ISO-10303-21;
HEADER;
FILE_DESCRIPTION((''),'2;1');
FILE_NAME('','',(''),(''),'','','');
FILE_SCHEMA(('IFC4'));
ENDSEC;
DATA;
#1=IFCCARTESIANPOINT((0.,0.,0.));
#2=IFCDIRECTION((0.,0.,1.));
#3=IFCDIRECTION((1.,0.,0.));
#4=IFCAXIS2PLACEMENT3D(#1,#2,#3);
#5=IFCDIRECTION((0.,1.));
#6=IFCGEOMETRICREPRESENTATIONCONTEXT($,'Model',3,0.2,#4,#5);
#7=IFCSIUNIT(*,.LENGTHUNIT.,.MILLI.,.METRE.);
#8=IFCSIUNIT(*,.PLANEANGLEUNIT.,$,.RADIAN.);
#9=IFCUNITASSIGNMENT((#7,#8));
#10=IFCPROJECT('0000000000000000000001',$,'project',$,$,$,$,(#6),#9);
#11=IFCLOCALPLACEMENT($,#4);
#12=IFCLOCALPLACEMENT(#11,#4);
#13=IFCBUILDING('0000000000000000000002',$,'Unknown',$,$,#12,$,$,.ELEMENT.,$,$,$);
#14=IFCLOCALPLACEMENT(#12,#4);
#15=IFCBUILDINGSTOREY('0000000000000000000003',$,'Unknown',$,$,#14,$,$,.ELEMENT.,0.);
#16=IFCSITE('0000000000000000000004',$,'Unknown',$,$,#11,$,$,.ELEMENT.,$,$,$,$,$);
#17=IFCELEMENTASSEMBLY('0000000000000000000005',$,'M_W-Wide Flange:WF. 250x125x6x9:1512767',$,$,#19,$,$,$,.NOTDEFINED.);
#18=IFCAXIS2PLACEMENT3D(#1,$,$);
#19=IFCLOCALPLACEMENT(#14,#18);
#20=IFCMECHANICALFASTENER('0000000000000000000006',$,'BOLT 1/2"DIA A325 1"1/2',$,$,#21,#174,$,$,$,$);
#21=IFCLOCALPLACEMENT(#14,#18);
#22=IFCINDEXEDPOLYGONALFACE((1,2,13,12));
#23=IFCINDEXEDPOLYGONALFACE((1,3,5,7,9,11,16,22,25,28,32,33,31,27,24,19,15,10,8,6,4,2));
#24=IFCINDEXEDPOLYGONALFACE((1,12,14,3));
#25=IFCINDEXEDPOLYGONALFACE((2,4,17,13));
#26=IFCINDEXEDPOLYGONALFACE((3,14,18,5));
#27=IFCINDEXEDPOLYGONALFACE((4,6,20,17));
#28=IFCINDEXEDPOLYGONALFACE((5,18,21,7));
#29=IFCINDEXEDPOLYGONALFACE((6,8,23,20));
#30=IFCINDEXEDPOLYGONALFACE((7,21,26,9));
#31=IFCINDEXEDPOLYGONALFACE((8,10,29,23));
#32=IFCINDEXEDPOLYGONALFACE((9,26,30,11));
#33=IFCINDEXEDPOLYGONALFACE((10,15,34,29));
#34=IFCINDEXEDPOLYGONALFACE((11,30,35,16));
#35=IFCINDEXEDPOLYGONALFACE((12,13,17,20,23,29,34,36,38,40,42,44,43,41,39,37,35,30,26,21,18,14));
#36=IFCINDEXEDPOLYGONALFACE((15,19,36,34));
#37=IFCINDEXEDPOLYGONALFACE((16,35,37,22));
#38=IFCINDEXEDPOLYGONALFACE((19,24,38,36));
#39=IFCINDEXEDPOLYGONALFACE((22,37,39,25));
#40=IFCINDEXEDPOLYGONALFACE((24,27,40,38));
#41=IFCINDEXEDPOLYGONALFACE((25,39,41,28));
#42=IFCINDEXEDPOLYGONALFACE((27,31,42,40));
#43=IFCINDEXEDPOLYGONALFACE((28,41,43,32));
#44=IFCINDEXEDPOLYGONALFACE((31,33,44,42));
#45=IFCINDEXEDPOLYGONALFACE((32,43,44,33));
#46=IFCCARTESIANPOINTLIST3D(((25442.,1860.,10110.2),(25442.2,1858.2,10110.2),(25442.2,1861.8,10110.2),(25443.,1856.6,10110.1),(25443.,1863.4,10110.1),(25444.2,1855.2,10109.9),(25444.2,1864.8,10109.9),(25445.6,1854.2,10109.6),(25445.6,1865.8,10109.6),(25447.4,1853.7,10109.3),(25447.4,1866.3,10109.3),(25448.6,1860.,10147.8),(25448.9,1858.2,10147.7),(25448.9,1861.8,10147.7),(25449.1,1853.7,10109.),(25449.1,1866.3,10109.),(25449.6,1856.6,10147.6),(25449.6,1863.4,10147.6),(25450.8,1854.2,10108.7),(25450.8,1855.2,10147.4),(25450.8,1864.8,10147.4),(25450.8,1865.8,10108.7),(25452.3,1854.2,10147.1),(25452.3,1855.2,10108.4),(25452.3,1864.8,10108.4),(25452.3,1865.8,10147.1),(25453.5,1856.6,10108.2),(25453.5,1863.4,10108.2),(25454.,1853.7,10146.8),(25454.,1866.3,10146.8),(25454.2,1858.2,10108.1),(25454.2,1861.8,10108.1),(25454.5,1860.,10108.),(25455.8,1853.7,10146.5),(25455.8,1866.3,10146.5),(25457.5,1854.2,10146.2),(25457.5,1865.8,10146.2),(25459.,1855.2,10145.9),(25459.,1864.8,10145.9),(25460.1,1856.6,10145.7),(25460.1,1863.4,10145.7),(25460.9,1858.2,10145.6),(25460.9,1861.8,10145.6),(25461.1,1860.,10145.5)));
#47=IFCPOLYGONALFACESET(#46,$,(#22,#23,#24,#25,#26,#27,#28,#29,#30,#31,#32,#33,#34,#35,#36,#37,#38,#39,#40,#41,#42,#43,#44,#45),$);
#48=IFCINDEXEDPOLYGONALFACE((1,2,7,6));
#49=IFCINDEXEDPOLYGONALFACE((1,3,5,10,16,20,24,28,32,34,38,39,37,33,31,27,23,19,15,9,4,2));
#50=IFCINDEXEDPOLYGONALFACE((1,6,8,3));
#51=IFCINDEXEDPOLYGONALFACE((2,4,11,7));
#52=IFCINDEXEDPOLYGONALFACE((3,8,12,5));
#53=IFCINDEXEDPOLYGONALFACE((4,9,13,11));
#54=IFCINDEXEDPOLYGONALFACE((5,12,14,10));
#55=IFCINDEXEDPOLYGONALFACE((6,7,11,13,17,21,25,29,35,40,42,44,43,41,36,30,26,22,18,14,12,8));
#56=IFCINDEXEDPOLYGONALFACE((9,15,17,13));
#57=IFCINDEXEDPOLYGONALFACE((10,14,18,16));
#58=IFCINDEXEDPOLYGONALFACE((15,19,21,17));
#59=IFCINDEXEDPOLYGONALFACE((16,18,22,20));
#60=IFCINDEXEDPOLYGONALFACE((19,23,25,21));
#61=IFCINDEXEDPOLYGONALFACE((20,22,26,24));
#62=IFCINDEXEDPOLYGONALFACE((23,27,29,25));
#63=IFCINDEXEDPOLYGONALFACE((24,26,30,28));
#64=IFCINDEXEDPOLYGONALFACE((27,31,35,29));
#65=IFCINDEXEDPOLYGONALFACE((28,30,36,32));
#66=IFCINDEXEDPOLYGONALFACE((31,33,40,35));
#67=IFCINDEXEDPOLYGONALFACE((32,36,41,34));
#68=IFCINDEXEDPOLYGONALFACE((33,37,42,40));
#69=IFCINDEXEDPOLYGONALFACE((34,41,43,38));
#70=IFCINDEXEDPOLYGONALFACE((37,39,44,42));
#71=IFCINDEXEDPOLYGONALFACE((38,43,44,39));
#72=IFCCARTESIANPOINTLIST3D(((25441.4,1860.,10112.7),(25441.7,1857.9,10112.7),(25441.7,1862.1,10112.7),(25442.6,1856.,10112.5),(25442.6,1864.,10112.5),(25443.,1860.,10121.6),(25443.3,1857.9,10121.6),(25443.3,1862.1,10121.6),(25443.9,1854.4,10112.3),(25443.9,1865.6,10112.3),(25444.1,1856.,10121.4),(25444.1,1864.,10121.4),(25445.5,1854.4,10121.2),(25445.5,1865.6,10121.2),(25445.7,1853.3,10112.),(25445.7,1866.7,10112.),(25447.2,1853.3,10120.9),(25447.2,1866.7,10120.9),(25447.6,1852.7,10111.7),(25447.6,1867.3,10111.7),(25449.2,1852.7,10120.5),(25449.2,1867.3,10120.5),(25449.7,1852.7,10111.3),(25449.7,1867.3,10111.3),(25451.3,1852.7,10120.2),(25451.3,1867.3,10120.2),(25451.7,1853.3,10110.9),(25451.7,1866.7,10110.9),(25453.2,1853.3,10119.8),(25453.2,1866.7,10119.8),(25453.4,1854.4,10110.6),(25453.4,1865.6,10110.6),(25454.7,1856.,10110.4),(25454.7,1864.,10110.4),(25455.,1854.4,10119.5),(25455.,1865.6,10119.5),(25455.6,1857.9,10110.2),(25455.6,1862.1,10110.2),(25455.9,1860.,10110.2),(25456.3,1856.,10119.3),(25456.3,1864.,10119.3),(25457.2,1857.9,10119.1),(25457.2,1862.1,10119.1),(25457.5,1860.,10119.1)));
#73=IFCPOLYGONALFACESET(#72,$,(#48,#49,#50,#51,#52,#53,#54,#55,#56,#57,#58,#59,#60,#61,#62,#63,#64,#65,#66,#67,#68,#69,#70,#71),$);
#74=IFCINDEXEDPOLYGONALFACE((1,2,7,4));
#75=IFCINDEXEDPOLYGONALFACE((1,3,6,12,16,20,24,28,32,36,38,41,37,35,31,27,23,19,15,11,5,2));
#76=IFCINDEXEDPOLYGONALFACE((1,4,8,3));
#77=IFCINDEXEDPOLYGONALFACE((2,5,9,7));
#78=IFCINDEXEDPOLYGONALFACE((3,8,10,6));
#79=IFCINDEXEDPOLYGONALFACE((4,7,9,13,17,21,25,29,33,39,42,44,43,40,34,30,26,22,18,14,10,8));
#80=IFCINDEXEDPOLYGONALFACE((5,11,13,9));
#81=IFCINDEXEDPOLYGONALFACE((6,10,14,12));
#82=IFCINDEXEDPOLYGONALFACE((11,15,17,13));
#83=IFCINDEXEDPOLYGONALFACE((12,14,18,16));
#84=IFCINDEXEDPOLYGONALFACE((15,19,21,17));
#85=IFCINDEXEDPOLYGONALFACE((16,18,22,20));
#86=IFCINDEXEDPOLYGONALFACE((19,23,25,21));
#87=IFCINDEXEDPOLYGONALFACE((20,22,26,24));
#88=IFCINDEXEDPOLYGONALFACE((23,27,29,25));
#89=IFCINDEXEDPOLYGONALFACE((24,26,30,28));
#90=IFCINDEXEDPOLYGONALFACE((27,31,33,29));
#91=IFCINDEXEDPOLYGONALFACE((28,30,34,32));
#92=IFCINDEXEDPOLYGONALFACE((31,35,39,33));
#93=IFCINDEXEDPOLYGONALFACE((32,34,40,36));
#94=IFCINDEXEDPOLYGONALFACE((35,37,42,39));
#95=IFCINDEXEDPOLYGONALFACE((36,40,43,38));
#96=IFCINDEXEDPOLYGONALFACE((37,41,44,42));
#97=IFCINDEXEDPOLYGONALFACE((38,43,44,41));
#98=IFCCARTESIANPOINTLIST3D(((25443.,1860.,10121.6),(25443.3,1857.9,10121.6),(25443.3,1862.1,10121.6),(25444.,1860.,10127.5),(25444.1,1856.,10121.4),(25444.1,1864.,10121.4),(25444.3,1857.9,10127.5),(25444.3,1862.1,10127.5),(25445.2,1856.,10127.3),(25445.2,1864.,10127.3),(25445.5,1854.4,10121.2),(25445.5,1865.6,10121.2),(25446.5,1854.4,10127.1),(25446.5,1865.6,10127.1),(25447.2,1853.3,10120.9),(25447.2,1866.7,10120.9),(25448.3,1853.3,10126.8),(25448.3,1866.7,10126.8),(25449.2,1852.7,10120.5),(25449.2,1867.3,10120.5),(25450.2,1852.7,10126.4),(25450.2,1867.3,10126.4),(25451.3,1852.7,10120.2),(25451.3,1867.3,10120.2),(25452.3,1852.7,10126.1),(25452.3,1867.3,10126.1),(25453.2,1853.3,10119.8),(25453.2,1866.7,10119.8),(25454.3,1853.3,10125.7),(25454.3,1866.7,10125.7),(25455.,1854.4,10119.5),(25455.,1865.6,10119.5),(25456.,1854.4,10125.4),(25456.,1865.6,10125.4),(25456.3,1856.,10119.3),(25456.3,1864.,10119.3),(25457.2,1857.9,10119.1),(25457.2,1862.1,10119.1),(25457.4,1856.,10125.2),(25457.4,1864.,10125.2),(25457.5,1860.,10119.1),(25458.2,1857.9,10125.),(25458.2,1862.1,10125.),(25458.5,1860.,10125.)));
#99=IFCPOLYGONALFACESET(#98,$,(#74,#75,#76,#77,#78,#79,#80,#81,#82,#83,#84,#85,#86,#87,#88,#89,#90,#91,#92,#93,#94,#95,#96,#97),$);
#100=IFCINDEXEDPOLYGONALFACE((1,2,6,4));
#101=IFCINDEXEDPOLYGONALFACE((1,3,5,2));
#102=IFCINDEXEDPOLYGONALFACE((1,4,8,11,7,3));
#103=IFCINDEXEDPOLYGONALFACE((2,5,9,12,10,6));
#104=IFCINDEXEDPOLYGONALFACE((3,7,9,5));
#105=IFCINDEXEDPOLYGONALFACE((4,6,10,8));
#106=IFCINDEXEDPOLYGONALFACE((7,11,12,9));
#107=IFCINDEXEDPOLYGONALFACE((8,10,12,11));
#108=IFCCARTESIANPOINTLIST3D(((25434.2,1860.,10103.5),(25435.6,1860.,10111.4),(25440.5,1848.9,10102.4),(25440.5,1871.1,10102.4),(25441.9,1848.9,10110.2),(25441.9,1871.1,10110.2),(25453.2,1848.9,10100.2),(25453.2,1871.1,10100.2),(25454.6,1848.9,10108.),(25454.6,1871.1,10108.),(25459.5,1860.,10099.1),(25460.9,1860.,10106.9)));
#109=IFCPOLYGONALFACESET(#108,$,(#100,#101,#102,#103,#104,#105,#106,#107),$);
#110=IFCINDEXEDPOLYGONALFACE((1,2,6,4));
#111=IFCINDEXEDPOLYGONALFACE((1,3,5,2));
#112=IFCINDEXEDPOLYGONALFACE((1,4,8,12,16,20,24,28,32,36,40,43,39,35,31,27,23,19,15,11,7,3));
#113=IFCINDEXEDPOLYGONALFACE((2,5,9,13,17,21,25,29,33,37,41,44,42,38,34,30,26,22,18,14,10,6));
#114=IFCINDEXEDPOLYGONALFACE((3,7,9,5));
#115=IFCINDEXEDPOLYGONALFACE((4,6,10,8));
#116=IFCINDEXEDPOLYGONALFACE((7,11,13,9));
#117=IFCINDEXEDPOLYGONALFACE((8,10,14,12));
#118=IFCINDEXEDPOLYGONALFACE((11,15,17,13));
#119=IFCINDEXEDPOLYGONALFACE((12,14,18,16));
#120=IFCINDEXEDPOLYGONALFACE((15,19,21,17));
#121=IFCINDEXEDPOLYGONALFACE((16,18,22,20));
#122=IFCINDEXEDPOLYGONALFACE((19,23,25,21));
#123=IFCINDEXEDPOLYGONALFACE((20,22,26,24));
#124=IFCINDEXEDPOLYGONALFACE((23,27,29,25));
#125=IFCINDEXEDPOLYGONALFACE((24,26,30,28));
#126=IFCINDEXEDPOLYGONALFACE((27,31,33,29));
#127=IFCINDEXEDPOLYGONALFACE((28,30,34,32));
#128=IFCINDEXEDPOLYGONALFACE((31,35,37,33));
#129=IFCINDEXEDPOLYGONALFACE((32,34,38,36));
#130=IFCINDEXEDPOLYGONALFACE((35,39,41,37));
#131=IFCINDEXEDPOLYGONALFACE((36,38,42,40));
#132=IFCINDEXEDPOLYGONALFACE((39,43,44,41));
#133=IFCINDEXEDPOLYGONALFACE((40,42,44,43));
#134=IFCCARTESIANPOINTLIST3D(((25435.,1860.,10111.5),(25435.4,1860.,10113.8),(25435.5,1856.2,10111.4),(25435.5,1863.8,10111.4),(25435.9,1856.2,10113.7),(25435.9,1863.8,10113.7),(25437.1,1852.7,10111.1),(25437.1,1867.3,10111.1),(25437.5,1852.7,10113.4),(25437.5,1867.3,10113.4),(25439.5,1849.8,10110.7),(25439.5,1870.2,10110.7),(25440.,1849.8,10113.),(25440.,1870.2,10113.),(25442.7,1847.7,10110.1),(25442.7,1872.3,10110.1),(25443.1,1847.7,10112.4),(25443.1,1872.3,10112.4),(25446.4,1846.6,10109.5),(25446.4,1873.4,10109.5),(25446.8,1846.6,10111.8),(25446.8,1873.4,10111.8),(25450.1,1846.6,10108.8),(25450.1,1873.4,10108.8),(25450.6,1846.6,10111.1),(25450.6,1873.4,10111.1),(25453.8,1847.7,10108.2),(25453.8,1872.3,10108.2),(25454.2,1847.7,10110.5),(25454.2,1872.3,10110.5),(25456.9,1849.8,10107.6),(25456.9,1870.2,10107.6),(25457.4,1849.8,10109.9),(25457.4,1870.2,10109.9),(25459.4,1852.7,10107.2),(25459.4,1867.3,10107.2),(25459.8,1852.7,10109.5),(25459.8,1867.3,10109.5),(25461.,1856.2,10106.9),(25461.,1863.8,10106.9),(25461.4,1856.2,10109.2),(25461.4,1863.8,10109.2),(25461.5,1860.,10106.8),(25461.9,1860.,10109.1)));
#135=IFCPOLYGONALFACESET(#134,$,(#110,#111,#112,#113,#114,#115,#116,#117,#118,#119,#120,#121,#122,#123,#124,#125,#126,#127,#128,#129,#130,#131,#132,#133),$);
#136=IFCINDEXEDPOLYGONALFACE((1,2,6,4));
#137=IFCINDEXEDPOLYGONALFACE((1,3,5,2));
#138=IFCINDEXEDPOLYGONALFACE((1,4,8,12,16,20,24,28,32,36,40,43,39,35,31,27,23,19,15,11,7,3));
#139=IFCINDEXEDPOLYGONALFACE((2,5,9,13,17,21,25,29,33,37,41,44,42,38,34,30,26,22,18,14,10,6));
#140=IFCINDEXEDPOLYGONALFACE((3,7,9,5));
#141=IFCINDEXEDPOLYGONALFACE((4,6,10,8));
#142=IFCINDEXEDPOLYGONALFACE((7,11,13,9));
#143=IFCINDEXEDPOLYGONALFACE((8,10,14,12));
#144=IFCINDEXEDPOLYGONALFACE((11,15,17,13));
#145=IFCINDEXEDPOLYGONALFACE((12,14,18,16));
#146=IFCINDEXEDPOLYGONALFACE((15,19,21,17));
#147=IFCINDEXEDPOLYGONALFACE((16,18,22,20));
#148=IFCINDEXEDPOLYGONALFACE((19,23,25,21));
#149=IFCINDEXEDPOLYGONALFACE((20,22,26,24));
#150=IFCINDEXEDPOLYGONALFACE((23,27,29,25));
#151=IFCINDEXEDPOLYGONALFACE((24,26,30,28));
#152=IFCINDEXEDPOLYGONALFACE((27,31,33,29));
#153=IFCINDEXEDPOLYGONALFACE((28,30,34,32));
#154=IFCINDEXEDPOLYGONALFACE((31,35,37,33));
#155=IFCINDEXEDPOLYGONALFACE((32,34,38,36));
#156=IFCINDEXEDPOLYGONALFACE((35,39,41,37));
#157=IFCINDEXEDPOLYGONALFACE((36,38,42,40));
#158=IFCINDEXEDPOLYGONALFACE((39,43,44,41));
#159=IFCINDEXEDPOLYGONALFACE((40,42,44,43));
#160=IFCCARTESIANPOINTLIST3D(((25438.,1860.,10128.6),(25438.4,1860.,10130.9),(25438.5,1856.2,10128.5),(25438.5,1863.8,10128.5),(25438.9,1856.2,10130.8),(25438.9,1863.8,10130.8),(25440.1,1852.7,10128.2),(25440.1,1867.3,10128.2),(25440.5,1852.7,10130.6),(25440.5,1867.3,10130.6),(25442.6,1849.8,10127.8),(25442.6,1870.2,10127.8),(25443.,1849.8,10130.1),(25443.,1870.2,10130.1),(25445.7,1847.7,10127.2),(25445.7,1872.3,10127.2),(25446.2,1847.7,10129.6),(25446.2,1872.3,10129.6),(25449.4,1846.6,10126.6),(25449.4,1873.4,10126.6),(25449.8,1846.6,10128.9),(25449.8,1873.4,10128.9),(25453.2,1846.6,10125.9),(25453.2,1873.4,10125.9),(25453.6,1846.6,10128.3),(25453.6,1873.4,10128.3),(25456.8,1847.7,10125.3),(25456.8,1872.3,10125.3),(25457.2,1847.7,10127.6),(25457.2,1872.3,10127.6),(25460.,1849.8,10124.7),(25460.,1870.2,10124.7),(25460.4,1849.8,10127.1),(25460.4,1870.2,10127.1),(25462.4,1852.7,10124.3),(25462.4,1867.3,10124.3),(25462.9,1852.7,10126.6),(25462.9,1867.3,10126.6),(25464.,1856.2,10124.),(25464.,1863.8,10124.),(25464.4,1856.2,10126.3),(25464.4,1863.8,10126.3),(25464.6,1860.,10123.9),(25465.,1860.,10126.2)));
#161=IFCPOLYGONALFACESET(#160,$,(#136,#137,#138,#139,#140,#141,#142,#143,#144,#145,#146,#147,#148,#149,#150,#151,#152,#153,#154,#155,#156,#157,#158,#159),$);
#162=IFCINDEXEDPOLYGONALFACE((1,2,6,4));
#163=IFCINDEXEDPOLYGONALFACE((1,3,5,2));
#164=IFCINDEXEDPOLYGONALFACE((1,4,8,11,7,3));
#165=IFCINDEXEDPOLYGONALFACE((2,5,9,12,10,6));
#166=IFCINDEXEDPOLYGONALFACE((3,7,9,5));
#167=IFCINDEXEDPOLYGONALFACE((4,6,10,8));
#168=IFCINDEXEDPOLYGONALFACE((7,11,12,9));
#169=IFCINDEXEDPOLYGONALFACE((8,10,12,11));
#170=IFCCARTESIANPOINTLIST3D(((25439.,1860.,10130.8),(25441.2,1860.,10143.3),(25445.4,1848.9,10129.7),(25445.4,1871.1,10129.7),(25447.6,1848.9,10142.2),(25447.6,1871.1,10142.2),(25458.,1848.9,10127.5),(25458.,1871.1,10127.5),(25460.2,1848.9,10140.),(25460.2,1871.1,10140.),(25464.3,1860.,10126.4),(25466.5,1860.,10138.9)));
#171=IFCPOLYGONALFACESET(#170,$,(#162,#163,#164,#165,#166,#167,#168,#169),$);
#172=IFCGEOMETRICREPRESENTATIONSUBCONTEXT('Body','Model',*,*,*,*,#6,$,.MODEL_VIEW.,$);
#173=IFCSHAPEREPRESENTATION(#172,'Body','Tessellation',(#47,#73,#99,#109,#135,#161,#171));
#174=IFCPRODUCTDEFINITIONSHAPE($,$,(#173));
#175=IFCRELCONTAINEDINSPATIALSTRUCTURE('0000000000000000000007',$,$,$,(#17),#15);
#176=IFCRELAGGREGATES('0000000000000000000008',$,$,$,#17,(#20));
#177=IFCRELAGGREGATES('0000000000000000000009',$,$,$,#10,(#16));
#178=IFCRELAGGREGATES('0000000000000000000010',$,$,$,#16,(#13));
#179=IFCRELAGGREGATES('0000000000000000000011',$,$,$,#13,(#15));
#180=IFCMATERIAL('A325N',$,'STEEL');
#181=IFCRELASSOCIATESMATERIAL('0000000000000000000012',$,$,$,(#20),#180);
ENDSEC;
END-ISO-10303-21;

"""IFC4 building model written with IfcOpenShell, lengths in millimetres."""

from ifc_helpers import new_model, si_unit, direction, frame, origin_with_axes, place, context, subcontext, project, spatial, line, arc, indexed_curve, outline, extrude, source, transform, mapped, material, element, aggregate, save


model = new_model("IFC4")

# Units and contexts
model_context = context("Model", 3, precision=0.2, world=origin_with_axes(), true_north=direction((0.0, 1.0)))
body_context = subcontext(model_context, "Body", "Model", "MODEL_VIEW")
ifc_project = project(units=[si_unit("LENGTHUNIT", "METRE", prefix="MILLI"), si_unit("PLANEANGLEUNIT", "RADIAN")], contexts=[model_context])

# Site, building, storey
site_placement = place(None, origin_with_axes())
site = spatial("IfcSite", under=ifc_project, at=site_placement, Name="Unknown", CompositionType="ELEMENT")
building_placement = place(site_placement, origin_with_axes())
building = spatial("IfcBuilding", under=site, at=building_placement, Name="Unknown", CompositionType="ELEMENT")
storey_placement = place(building_placement, origin_with_axes())
storey = spatial("IfcBuildingStorey", under=building, at=storey_placement, Name="Unknown", CompositionType="ELEMENT", Elevation=0.0)

# Shared definitions
ifc_material_1 = material(Name="A325N", Category="STEEL")
shared_shape_1 = source(origin_with_axes(), body_context, "Body", "SweptSolid", [
    extrude(outline(indexed_curve([(6.3, 0.0), (0.0, 6.3), (-6.3, 0.0), (0.0, -6.3)], segments=[arc(1, 2, 3), arc(3, 4, 1)])), frame((0.0, 0.0, 17.4), z_axis=(0.0, 0.0, -1.0), x_axis=(0.0, 1.0, 0.0)), (0.0, 0.0, 1.0), 38.1),
    extrude(outline(indexed_curve([(7.3, 0.0), (0.0, 7.3), (-7.3, 0.0), (0.0, -7.3)], segments=[arc(1, 2, 3), arc(3, 4, 1)])), frame((0.0, 0.0, 15.0), z_axis=(0.0, 0.0, -1.0), x_axis=(0.0, 1.0, 0.0)), (0.0, 0.0, 1.0), 9.0),
    extrude(outline(indexed_curve([(7.3, 0.0), (0.0, 7.3), (-7.3, 0.0), (0.0, -7.3)], segments=[arc(1, 2, 3), arc(3, 4, 1)])), frame((0.0, 0.0, 6.0), z_axis=(0.0, 0.0, -1.0), x_axis=(0.0, 1.0, 0.0)), (0.0, 0.0, 1.0), 6.0),
    extrude(outline(indexed_curve([(12.8, 0.0), (6.4, 11.1), (-6.4, 11.1), (-12.8, 0.0), (-6.4, -11.1), (6.4, -11.1)], segments=[line(1, 2, 3, 4, 5, 6, 1)])), frame((0.0, 0.0, 25.3), z_axis=(0.0, 0.0, -1.0), x_axis=(0.0, 1.0, 0.0)), (0.0, 0.0, 1.0), 7.9),
    extrude(outline(indexed_curve([(13.5, 0.0), (0.0, 13.5), (-13.5, 0.0), (0.0, -13.5)], segments=[arc(1, 2, 3), arc(3, 4, 1)])), frame((0.0, 0.0, 17.4), z_axis=(0.0, 0.0, -1.0), x_axis=(0.0, 1.0, 0.0)), (0.0, 0.0, 1.0), 2.4),
    extrude(outline(indexed_curve([(13.5, 0.0), (0.0, 13.5), (-13.5, 0.0), (0.0, -13.5)], segments=[arc(1, 2, 3), arc(3, 4, 1)])), frame((0.0, 0.0, 0.0), z_axis=(0.0, 0.0, -1.0), x_axis=(0.0, 1.0, 0.0)), (0.0, 0.0, 1.0), 2.4),
    extrude(outline(indexed_curve([(12.8, 0.0), (6.4, 11.1), (-6.4, 11.1), (-12.8, 0.0), (-6.4, -11.1), (6.4, -11.1)], segments=[line(1, 2, 3, 4, 5, 6, 1)])), frame((0.0, 0.0, -2.4), z_axis=(0.0, 0.0, -1.0), x_axis=(0.0, 1.0, 0.0)), (0.0, 0.0, 1.0), 12.7),
])

# Element assembly, mechanical fastener
assembly_1_placement = place(storey_placement, frame((25460.5, 0.0, 9991.6), z_axis=(0.984808, 0.0, -0.173648), x_axis=(0.0, 1.0, 0.0)))
assembly_1 = element("IfcElementAssembly", 1, at=assembly_1_placement, inside=storey, Name="M_W-Wide Flange:WF. 250x125x6x9:1512767", PredefinedType="NOTDEFINED")
mechanical_fastener_1_placement = place(assembly_1_placement, frame((1860.0, 131.0, -32.5), z_axis=(0.0, -1.0, 0.0), x_axis=(1.0, 0.0, 0.0)))
mechanical_fastener_1 = element("IfcMechanicalFastener", 2, at=mechanical_fastener_1_placement, material=ifc_material_1, Name="BOLT 1/2\"DIA A325 1\"1/2", context=body_context, shape_type="MappedRepresentation", body=[
    mapped(shared_shape_1, transform((0.0, 0.0, 0.0))),
])
aggregate(assembly_1, [mechanical_fastener_1])

save(model, "model.ifc")
